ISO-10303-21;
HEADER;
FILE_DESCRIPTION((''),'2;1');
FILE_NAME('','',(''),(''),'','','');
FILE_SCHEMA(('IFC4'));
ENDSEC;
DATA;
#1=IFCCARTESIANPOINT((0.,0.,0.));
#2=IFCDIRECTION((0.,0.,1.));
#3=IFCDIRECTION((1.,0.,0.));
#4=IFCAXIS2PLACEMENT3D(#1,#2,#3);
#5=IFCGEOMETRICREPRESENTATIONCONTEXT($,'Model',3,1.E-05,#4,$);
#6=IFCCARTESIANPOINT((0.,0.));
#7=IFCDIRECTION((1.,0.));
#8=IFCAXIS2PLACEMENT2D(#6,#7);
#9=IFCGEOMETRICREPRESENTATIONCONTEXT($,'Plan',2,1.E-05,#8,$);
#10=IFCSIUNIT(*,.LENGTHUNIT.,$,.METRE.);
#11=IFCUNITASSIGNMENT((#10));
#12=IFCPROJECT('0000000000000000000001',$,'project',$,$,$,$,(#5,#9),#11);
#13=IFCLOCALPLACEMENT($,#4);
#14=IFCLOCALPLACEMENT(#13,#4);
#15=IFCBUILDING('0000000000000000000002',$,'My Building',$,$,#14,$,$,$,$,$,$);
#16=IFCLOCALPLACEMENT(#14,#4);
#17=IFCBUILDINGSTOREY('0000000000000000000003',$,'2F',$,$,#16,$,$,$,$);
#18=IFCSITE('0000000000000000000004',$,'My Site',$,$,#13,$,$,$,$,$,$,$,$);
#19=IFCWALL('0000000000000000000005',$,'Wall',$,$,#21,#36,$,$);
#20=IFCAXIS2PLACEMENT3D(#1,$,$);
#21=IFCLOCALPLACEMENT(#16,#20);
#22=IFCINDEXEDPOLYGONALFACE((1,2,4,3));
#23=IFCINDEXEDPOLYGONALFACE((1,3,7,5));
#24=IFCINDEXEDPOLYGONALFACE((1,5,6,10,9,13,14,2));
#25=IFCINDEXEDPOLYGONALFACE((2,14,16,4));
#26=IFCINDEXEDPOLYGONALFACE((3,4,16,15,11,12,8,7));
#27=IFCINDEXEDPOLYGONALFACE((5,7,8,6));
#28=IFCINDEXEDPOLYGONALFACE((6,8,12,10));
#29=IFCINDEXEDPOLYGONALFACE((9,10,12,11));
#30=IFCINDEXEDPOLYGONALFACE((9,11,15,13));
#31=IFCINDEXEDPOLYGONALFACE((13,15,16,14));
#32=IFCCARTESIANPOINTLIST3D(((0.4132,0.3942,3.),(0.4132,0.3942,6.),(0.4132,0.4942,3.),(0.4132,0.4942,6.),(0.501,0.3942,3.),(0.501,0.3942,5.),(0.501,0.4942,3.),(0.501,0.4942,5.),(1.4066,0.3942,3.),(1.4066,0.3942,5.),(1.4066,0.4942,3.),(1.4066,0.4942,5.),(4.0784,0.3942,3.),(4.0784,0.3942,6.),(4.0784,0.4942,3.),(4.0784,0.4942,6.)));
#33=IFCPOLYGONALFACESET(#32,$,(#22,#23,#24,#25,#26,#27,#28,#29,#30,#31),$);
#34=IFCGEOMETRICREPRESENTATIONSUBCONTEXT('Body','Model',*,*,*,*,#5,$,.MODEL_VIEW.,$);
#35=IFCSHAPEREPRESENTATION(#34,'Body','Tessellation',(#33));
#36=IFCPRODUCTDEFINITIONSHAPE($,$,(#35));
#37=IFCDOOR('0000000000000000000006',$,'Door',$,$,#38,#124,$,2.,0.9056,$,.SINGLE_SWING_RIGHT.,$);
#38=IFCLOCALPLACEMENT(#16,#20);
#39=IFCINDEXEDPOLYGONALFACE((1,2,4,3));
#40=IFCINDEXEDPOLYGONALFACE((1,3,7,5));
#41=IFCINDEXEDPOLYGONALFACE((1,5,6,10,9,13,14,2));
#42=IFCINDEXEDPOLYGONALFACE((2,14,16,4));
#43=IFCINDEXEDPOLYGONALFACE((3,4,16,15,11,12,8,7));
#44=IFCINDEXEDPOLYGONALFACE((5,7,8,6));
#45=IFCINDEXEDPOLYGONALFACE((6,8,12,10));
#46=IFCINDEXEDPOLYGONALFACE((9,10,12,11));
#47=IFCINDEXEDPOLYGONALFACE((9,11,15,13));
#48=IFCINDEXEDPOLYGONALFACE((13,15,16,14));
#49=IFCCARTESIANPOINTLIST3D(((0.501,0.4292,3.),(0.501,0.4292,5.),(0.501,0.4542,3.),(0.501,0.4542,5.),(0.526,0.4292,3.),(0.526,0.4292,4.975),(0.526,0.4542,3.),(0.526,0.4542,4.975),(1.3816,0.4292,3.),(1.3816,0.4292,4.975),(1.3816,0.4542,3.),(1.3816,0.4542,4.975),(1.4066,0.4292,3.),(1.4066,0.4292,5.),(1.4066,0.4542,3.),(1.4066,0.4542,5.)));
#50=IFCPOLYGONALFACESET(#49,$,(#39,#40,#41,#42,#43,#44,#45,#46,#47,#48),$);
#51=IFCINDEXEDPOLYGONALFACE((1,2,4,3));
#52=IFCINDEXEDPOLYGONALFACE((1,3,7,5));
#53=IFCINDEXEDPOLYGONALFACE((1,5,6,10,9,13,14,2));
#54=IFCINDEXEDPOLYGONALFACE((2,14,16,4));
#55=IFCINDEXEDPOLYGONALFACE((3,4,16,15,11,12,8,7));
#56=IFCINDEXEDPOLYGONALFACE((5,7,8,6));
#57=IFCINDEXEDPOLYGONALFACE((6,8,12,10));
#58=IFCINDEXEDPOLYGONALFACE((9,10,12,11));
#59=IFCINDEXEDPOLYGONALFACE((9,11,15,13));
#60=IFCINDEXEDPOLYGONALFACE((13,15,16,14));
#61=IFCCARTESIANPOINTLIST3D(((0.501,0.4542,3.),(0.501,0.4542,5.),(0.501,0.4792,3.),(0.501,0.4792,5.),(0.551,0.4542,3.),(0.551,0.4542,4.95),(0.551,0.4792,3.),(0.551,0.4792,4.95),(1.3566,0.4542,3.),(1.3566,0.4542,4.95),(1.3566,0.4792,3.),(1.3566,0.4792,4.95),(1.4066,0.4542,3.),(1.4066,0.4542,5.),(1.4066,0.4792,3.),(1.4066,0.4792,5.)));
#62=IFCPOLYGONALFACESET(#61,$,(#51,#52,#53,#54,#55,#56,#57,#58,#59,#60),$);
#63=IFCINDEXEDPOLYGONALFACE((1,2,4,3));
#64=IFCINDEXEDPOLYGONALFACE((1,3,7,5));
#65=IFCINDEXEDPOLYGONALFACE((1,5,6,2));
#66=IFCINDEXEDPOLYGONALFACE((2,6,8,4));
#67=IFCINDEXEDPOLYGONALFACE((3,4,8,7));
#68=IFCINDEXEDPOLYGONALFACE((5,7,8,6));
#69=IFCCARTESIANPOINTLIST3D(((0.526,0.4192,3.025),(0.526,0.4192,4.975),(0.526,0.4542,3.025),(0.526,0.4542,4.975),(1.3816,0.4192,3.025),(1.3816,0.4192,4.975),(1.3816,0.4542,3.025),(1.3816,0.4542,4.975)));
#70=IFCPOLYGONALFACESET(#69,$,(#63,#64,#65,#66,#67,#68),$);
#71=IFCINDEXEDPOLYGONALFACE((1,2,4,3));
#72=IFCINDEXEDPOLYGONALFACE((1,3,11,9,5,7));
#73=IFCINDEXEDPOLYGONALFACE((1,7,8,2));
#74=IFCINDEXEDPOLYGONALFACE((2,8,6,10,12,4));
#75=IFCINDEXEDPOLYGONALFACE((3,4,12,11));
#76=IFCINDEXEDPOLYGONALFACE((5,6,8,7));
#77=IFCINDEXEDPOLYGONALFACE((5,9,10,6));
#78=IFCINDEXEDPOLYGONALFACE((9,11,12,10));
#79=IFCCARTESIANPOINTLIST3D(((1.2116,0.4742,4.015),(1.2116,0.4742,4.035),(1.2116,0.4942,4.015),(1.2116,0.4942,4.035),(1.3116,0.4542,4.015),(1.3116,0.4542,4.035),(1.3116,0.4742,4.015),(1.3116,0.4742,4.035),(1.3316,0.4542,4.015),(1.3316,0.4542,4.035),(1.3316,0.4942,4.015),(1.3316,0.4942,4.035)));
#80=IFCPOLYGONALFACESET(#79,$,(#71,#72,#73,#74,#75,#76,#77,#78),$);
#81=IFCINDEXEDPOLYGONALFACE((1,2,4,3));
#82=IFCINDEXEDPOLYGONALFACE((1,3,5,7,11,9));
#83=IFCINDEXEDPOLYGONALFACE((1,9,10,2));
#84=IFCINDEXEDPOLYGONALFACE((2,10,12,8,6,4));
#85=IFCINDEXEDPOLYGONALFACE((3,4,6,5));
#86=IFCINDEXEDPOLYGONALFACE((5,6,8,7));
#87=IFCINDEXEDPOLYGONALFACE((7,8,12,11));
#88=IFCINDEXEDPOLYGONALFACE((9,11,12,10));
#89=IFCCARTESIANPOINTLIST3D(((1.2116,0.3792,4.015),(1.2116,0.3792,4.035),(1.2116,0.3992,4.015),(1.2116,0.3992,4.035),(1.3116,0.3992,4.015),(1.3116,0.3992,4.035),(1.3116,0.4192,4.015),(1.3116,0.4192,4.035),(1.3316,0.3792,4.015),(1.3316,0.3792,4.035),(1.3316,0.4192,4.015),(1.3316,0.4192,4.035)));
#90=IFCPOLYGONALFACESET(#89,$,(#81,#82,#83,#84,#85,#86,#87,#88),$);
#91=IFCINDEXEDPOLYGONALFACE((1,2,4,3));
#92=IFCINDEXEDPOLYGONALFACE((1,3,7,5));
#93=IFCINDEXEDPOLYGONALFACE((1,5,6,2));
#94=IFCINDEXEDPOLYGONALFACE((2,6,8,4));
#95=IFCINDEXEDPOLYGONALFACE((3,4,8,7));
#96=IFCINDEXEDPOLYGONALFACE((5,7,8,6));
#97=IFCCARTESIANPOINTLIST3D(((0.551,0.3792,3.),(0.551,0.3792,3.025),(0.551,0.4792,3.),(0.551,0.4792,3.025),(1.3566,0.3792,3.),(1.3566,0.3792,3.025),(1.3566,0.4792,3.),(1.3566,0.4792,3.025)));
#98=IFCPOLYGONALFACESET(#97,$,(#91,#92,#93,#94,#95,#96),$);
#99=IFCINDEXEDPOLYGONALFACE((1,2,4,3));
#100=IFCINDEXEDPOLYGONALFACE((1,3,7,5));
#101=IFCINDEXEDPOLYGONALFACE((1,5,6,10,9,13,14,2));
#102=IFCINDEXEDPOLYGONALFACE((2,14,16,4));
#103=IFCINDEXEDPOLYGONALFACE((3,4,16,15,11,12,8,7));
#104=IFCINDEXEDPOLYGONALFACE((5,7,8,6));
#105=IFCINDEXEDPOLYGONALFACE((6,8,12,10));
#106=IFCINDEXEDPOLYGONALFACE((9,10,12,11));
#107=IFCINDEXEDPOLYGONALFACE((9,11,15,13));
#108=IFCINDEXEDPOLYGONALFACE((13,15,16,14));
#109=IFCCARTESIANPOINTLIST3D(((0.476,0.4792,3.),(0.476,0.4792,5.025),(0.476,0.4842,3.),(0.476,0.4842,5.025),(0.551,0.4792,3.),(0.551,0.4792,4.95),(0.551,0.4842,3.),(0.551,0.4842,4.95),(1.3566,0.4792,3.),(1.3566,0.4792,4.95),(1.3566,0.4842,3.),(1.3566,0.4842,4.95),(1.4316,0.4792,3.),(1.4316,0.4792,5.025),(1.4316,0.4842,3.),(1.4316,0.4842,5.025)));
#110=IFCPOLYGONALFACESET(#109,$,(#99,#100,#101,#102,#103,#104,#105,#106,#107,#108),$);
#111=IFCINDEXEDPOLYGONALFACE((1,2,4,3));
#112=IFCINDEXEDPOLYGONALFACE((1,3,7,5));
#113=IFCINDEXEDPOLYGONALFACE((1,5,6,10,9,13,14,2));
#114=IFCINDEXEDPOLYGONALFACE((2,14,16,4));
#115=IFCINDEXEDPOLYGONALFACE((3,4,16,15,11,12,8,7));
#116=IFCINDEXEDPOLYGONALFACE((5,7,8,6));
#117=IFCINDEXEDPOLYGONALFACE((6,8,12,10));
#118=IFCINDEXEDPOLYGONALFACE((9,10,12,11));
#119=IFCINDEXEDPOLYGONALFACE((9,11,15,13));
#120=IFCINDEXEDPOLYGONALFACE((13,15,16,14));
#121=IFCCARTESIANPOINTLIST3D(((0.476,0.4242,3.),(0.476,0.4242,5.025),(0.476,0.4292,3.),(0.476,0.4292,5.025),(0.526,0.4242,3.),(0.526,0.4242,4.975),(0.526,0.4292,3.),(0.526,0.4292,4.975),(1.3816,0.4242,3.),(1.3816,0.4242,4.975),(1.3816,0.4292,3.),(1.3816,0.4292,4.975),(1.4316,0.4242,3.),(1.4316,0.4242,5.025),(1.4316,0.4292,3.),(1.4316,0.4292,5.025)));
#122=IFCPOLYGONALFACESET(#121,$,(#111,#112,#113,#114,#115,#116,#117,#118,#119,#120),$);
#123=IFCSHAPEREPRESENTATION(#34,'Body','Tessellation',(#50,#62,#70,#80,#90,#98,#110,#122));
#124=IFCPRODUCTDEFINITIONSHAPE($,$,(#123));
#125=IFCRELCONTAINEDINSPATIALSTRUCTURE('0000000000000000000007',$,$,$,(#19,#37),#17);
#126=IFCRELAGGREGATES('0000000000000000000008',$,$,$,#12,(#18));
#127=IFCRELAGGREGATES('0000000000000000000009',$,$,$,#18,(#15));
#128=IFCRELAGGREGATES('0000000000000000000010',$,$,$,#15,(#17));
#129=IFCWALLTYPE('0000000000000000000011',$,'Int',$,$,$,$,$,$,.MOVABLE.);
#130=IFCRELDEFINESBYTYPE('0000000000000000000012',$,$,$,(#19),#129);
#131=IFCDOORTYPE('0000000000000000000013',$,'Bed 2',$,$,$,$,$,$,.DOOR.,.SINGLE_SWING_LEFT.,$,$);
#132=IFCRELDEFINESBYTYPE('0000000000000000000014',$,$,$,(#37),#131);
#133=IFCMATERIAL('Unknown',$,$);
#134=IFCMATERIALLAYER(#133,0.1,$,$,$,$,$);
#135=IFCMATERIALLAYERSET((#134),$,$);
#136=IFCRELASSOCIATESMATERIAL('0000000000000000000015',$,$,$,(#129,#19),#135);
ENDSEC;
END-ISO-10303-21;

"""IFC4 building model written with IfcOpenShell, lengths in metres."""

from ifc_helpers import new_model, entity, si_unit, frame, origin_with_axes, origin_2d_with_axis, place, context, subcontext, project, spatial, line, indexed_curve, outline, extrude, shape, source, transform, mapped, material, layer, layer_set, layer_usage, type_object, type_shapes, element, fill, save


model = new_model("IFC4")

# Units and contexts
model_context = context("Model", 3, precision=1e-05, world=origin_with_axes())
plan_context = context("Plan", 2, precision=1e-05, world=origin_2d_with_axis())
body_context_1 = subcontext(model_context, "Body", "Model", "MODEL_VIEW")
body_context_2 = subcontext(plan_context, "Body", "Plan", "PLAN_VIEW")
ifc_project = project(units=[si_unit("LENGTHUNIT", "METRE")], contexts=[model_context, plan_context])

# Site, building, storey
site_placement = place(None, origin_with_axes())
site = spatial("IfcSite", under=ifc_project, at=site_placement, Name="My Site")
building_placement = place(site_placement, origin_with_axes())
building = spatial("IfcBuilding", under=site, at=building_placement, Name="My Building")
storey_placement = place(building_placement, origin_with_axes())
storey = spatial("IfcBuildingStorey", under=building, at=storey_placement, Name="2F")

# Shared definitions
ifc_material = material(Name="Unknown")

# Shared definitions
ifc_layer_1 = layer(ifc_material, 0.1)
ifc_layer_set_1 = layer_set([ifc_layer_1])
wall_type_1 = type_object("IfcWallType", Name="Int", PredefinedType="MOVABLE", material=ifc_layer_set_1)

# Wall, opening, door
ifc_layer_usage_1 = layer_usage(ifc_layer_set_1, "AXIS2", "POSITIVE", 0.0)
wall_1_placement = place(storey_placement, frame((0.4132, 0.3942, 3.0), z_axis=(0.0, 0.0, 1.0), x_axis=(1.0, 0.0, 0.0)))
wall_1 = element("IfcWall", 1, at=wall_1_placement, inside=storey, type_object=wall_type_1, material=ifc_layer_usage_1, Name="Wall", context=body_context_1, shape_type="SweptSolid", body=[
    extrude(outline(indexed_curve([(0.0, 0.0), (0.0, 0.1), (3.6652, 0.1), (3.6652, 0.0)], segments=[line(1, 2, 3, 4, 1)])), origin_with_axes(), (0.0, 0.0, 1.0), 3.0),
])
shared_shape_1 = source(origin_with_axes(), body_context_1, "Body", "SweptSolid", [
    extrude(outline(indexed_curve([(0.0, 0.0), (0.9056, 0.0), (0.9056, 2.0), (0.0, 2.0)], segments=[line(1, 2, 3, 4, 1)])), frame((0.0, -0.6, 0.0), z_axis=(0.0, -1.0, 0.0), x_axis=(1.0, 0.0, 0.0)), (0.0, 0.0, -1.0), 1.2),
])
opening_1_placement = place(wall_1_placement, frame((0.9934, 0.085, 0.0), z_axis=(0.0, 0.0, 1.0), x_axis=(-1.0, 0.0, 0.0)))
opening_1 = element("IfcOpeningElement", 2, at=opening_1_placement, cuts=wall_1, PredefinedType="OPENING", context=body_context_1, shape_type="MappedRepresentation", body=[
    mapped(shared_shape_1, transform((0.0, 0.0, 0.0), x_axis=(1.0, 0.0, 0.0), y_axis=(0.0, 1.0, 0.0), z_axis=(0.0, 0.0, 1.0), scale=1.0)),
])
door_type_1 = type_object("IfcDoorType", Name="Bed 2", OperationType="SINGLE_SWING_LEFT", PredefinedType="DOOR")
shared_shape_2 = source(origin_with_axes(), body_context_1, "Body", "SweptSolid", [
    extrude(outline(indexed_curve([(0.0, 0.0), (0.0, 2.0), (0.9056, 2.0), (0.9056, 0.0), (0.8806, 0.0), (0.8806, 1.975), (0.025, 1.975), (0.025, 0.0)], segments=[line(1, 2, 3, 4, 5, 6, 7, 8, 1)])), frame((0.0, 0.025, 0.0), z_axis=(0.0, -1.0, 0.0), x_axis=(1.0, 0.0, 0.0)), (0.0, 0.0, -1.0), 0.025),
    extrude(outline(indexed_curve([(0.0, 0.0), (0.0, 2.0), (0.9056, 2.0), (0.9056, 0.0), (0.8556, 0.0), (0.8556, 1.95), (0.05, 1.95), (0.05, 0.0)], segments=[line(1, 2, 3, 4, 5, 6, 7, 8, 1)])), frame((0.0, 0.0, 0.0), z_axis=(0.0, -1.0, 0.0), x_axis=(1.0, 0.0, 0.0)), (0.0, 0.0, -1.0), 0.025),
    extrude(outline(indexed_curve([(0.0, 0.0), (0.8556, 0.0), (0.8556, 0.035), (0.0, 0.035)], segments=[line(1, 2, 3, 4, 1)])), frame((0.025, 0.025, 0.025), z_axis=(0.0, 0.0, 1.0), x_axis=(1.0, 0.0, 0.0)), (0.0, 0.0, 1.0), 1.95),
    extrude(outline(indexed_curve([(0.0, 0.0), (0.0, -0.04), (0.12, -0.04), (0.12, -0.02), (0.02, -0.02), (0.02, 0.0)], segments=[line(1, 2, 3, 4, 5, 6, 1)])), frame((0.075, 0.025, 1.015), z_axis=(0.0, 0.0, 1.0), x_axis=(1.0, 0.0, 0.0)), (0.0, 0.0, 1.0), 0.02),
    extrude(outline(indexed_curve([(0.0, 0.0), (0.0, 0.04), (0.12, 0.04), (0.12, 0.02), (0.02, 0.02), (0.02, 0.0)], segments=[line(1, 2, 3, 4, 5, 6, 1)])), frame((0.075, 0.06, 1.015), z_axis=(0.0, 0.0, 1.0), x_axis=(1.0, 0.0, 0.0)), (0.0, 0.0, 1.0), 0.02),
    extrude(outline(indexed_curve([(0.0, 0.0), (0.8056, 0.0), (0.8056, 0.1), (0.0, 0.1)], segments=[line(1, 2, 3, 4, 1)])), frame((0.05, 0.0, 0.0), z_axis=(0.0, 0.0, 1.0), x_axis=(1.0, 0.0, 0.0)), (0.0, 0.0, 1.0), 0.025),
    extrude(outline(indexed_curve([(0.0, 0.0), (0.0, 2.025), (0.9556, 2.025), (0.9556, 0.0), (0.8806, 0.0), (0.8806, 1.95), (0.075, 1.95), (0.075, 0.0)], segments=[line(1, 2, 3, 4, 5, 6, 7, 8, 1)])), frame((-0.025, -0.005, 0.0), z_axis=(0.0, -1.0, 0.0), x_axis=(1.0, 0.0, 0.0)), (0.0, 0.0, -1.0), 0.005),
    extrude(outline(indexed_curve([(0.0, 0.0), (0.0, 2.025), (0.9556, 2.025), (0.9556, 0.0), (0.9056, 0.0), (0.9056, 1.975), (0.05, 1.975), (0.05, 0.0)], segments=[line(1, 2, 3, 4, 5, 6, 7, 8, 1)])), frame((-0.025, 0.05, 0.0), z_axis=(0.0, -1.0, 0.0), x_axis=(1.0, 0.0, 0.0)), (0.0, 0.0, -1.0), 0.005),
])
shared_shape_3 = source(origin_with_axes(), body_context_2, "Body", "Curve2D", [
    entity("IfcIndexedPolyCurve", entity("IfcCartesianPointList2D", [[0.0, 0.0], [0.0, 0.05], [0.025, 0.05], [0.025, 0.025], [0.05, 0.025], [0.05, 0.0]]), [entity("IfcLineIndex", [1, 2, 3, 4, 5, 6, 1])]),
    entity("IfcIndexedPolyCurve", entity("IfcCartesianPointList2D", [[0.9056, 0.0], [0.9056, 0.05], [0.8806, 0.05], [0.8806, 0.025], [0.8556, 0.025], [0.8556, 0.0]]), [entity("IfcLineIndex", [1, 2, 3, 4, 5, 6, 1])]),
    entity("IfcTrimmedCurve", entity("IfcEllipse", entity("IfcAxis2Placement2D", entity("IfcCartesianPoint", [0.8456, 0.05]), entity("IfcDirection", [1.0, 0.0])), 0.8206, 0.8556), [entity("IfcCartesianPoint", [0.8456, 0.9056])], [entity("IfcCartesianPoint", [0.025, 0.05])], True, "CARTESIAN"),
    entity("IfcIndexedPolyCurve", entity("IfcCartesianPointList2D", [[0.8806, 0.05], [0.8456, 0.05], [0.8456, 0.9056], [0.8806, 0.9056]]), [entity("IfcLineIndex", [1, 2, 3, 4, 1])]),
])
type_shapes(door_type_1, [shared_shape_2, shared_shape_3])
door_1_placement = place(opening_1_placement, origin_with_axes())
door_1 = element("IfcDoor", 3, at=door_1_placement, inside=storey, type_object=door_type_1, Name="Door", OperationType="SINGLE_SWING_RIGHT", OverallHeight=2.0, OverallWidth=0.9056, shapes=[
    shape(body_context_1, "Body", "MappedRepresentation", [mapped(shared_shape_2, transform((0.0, 0.0, 0.0), x_axis=(1.0, 0.0, 0.0), y_axis=(0.0, 1.0, 0.0), z_axis=(0.0, 0.0, 1.0), scale=1.0))]),
    shape(body_context_2, "Body", "MappedRepresentation", [mapped(shared_shape_3, transform((0.0, 0.0, 0.0), x_axis=(1.0, 0.0, 0.0), y_axis=(0.0, 1.0, 0.0), z_axis=(0.0, 0.0, 1.0), scale=1.0))]),
])
fill(opening_1, door_1)

save(model, "model.ifc")
